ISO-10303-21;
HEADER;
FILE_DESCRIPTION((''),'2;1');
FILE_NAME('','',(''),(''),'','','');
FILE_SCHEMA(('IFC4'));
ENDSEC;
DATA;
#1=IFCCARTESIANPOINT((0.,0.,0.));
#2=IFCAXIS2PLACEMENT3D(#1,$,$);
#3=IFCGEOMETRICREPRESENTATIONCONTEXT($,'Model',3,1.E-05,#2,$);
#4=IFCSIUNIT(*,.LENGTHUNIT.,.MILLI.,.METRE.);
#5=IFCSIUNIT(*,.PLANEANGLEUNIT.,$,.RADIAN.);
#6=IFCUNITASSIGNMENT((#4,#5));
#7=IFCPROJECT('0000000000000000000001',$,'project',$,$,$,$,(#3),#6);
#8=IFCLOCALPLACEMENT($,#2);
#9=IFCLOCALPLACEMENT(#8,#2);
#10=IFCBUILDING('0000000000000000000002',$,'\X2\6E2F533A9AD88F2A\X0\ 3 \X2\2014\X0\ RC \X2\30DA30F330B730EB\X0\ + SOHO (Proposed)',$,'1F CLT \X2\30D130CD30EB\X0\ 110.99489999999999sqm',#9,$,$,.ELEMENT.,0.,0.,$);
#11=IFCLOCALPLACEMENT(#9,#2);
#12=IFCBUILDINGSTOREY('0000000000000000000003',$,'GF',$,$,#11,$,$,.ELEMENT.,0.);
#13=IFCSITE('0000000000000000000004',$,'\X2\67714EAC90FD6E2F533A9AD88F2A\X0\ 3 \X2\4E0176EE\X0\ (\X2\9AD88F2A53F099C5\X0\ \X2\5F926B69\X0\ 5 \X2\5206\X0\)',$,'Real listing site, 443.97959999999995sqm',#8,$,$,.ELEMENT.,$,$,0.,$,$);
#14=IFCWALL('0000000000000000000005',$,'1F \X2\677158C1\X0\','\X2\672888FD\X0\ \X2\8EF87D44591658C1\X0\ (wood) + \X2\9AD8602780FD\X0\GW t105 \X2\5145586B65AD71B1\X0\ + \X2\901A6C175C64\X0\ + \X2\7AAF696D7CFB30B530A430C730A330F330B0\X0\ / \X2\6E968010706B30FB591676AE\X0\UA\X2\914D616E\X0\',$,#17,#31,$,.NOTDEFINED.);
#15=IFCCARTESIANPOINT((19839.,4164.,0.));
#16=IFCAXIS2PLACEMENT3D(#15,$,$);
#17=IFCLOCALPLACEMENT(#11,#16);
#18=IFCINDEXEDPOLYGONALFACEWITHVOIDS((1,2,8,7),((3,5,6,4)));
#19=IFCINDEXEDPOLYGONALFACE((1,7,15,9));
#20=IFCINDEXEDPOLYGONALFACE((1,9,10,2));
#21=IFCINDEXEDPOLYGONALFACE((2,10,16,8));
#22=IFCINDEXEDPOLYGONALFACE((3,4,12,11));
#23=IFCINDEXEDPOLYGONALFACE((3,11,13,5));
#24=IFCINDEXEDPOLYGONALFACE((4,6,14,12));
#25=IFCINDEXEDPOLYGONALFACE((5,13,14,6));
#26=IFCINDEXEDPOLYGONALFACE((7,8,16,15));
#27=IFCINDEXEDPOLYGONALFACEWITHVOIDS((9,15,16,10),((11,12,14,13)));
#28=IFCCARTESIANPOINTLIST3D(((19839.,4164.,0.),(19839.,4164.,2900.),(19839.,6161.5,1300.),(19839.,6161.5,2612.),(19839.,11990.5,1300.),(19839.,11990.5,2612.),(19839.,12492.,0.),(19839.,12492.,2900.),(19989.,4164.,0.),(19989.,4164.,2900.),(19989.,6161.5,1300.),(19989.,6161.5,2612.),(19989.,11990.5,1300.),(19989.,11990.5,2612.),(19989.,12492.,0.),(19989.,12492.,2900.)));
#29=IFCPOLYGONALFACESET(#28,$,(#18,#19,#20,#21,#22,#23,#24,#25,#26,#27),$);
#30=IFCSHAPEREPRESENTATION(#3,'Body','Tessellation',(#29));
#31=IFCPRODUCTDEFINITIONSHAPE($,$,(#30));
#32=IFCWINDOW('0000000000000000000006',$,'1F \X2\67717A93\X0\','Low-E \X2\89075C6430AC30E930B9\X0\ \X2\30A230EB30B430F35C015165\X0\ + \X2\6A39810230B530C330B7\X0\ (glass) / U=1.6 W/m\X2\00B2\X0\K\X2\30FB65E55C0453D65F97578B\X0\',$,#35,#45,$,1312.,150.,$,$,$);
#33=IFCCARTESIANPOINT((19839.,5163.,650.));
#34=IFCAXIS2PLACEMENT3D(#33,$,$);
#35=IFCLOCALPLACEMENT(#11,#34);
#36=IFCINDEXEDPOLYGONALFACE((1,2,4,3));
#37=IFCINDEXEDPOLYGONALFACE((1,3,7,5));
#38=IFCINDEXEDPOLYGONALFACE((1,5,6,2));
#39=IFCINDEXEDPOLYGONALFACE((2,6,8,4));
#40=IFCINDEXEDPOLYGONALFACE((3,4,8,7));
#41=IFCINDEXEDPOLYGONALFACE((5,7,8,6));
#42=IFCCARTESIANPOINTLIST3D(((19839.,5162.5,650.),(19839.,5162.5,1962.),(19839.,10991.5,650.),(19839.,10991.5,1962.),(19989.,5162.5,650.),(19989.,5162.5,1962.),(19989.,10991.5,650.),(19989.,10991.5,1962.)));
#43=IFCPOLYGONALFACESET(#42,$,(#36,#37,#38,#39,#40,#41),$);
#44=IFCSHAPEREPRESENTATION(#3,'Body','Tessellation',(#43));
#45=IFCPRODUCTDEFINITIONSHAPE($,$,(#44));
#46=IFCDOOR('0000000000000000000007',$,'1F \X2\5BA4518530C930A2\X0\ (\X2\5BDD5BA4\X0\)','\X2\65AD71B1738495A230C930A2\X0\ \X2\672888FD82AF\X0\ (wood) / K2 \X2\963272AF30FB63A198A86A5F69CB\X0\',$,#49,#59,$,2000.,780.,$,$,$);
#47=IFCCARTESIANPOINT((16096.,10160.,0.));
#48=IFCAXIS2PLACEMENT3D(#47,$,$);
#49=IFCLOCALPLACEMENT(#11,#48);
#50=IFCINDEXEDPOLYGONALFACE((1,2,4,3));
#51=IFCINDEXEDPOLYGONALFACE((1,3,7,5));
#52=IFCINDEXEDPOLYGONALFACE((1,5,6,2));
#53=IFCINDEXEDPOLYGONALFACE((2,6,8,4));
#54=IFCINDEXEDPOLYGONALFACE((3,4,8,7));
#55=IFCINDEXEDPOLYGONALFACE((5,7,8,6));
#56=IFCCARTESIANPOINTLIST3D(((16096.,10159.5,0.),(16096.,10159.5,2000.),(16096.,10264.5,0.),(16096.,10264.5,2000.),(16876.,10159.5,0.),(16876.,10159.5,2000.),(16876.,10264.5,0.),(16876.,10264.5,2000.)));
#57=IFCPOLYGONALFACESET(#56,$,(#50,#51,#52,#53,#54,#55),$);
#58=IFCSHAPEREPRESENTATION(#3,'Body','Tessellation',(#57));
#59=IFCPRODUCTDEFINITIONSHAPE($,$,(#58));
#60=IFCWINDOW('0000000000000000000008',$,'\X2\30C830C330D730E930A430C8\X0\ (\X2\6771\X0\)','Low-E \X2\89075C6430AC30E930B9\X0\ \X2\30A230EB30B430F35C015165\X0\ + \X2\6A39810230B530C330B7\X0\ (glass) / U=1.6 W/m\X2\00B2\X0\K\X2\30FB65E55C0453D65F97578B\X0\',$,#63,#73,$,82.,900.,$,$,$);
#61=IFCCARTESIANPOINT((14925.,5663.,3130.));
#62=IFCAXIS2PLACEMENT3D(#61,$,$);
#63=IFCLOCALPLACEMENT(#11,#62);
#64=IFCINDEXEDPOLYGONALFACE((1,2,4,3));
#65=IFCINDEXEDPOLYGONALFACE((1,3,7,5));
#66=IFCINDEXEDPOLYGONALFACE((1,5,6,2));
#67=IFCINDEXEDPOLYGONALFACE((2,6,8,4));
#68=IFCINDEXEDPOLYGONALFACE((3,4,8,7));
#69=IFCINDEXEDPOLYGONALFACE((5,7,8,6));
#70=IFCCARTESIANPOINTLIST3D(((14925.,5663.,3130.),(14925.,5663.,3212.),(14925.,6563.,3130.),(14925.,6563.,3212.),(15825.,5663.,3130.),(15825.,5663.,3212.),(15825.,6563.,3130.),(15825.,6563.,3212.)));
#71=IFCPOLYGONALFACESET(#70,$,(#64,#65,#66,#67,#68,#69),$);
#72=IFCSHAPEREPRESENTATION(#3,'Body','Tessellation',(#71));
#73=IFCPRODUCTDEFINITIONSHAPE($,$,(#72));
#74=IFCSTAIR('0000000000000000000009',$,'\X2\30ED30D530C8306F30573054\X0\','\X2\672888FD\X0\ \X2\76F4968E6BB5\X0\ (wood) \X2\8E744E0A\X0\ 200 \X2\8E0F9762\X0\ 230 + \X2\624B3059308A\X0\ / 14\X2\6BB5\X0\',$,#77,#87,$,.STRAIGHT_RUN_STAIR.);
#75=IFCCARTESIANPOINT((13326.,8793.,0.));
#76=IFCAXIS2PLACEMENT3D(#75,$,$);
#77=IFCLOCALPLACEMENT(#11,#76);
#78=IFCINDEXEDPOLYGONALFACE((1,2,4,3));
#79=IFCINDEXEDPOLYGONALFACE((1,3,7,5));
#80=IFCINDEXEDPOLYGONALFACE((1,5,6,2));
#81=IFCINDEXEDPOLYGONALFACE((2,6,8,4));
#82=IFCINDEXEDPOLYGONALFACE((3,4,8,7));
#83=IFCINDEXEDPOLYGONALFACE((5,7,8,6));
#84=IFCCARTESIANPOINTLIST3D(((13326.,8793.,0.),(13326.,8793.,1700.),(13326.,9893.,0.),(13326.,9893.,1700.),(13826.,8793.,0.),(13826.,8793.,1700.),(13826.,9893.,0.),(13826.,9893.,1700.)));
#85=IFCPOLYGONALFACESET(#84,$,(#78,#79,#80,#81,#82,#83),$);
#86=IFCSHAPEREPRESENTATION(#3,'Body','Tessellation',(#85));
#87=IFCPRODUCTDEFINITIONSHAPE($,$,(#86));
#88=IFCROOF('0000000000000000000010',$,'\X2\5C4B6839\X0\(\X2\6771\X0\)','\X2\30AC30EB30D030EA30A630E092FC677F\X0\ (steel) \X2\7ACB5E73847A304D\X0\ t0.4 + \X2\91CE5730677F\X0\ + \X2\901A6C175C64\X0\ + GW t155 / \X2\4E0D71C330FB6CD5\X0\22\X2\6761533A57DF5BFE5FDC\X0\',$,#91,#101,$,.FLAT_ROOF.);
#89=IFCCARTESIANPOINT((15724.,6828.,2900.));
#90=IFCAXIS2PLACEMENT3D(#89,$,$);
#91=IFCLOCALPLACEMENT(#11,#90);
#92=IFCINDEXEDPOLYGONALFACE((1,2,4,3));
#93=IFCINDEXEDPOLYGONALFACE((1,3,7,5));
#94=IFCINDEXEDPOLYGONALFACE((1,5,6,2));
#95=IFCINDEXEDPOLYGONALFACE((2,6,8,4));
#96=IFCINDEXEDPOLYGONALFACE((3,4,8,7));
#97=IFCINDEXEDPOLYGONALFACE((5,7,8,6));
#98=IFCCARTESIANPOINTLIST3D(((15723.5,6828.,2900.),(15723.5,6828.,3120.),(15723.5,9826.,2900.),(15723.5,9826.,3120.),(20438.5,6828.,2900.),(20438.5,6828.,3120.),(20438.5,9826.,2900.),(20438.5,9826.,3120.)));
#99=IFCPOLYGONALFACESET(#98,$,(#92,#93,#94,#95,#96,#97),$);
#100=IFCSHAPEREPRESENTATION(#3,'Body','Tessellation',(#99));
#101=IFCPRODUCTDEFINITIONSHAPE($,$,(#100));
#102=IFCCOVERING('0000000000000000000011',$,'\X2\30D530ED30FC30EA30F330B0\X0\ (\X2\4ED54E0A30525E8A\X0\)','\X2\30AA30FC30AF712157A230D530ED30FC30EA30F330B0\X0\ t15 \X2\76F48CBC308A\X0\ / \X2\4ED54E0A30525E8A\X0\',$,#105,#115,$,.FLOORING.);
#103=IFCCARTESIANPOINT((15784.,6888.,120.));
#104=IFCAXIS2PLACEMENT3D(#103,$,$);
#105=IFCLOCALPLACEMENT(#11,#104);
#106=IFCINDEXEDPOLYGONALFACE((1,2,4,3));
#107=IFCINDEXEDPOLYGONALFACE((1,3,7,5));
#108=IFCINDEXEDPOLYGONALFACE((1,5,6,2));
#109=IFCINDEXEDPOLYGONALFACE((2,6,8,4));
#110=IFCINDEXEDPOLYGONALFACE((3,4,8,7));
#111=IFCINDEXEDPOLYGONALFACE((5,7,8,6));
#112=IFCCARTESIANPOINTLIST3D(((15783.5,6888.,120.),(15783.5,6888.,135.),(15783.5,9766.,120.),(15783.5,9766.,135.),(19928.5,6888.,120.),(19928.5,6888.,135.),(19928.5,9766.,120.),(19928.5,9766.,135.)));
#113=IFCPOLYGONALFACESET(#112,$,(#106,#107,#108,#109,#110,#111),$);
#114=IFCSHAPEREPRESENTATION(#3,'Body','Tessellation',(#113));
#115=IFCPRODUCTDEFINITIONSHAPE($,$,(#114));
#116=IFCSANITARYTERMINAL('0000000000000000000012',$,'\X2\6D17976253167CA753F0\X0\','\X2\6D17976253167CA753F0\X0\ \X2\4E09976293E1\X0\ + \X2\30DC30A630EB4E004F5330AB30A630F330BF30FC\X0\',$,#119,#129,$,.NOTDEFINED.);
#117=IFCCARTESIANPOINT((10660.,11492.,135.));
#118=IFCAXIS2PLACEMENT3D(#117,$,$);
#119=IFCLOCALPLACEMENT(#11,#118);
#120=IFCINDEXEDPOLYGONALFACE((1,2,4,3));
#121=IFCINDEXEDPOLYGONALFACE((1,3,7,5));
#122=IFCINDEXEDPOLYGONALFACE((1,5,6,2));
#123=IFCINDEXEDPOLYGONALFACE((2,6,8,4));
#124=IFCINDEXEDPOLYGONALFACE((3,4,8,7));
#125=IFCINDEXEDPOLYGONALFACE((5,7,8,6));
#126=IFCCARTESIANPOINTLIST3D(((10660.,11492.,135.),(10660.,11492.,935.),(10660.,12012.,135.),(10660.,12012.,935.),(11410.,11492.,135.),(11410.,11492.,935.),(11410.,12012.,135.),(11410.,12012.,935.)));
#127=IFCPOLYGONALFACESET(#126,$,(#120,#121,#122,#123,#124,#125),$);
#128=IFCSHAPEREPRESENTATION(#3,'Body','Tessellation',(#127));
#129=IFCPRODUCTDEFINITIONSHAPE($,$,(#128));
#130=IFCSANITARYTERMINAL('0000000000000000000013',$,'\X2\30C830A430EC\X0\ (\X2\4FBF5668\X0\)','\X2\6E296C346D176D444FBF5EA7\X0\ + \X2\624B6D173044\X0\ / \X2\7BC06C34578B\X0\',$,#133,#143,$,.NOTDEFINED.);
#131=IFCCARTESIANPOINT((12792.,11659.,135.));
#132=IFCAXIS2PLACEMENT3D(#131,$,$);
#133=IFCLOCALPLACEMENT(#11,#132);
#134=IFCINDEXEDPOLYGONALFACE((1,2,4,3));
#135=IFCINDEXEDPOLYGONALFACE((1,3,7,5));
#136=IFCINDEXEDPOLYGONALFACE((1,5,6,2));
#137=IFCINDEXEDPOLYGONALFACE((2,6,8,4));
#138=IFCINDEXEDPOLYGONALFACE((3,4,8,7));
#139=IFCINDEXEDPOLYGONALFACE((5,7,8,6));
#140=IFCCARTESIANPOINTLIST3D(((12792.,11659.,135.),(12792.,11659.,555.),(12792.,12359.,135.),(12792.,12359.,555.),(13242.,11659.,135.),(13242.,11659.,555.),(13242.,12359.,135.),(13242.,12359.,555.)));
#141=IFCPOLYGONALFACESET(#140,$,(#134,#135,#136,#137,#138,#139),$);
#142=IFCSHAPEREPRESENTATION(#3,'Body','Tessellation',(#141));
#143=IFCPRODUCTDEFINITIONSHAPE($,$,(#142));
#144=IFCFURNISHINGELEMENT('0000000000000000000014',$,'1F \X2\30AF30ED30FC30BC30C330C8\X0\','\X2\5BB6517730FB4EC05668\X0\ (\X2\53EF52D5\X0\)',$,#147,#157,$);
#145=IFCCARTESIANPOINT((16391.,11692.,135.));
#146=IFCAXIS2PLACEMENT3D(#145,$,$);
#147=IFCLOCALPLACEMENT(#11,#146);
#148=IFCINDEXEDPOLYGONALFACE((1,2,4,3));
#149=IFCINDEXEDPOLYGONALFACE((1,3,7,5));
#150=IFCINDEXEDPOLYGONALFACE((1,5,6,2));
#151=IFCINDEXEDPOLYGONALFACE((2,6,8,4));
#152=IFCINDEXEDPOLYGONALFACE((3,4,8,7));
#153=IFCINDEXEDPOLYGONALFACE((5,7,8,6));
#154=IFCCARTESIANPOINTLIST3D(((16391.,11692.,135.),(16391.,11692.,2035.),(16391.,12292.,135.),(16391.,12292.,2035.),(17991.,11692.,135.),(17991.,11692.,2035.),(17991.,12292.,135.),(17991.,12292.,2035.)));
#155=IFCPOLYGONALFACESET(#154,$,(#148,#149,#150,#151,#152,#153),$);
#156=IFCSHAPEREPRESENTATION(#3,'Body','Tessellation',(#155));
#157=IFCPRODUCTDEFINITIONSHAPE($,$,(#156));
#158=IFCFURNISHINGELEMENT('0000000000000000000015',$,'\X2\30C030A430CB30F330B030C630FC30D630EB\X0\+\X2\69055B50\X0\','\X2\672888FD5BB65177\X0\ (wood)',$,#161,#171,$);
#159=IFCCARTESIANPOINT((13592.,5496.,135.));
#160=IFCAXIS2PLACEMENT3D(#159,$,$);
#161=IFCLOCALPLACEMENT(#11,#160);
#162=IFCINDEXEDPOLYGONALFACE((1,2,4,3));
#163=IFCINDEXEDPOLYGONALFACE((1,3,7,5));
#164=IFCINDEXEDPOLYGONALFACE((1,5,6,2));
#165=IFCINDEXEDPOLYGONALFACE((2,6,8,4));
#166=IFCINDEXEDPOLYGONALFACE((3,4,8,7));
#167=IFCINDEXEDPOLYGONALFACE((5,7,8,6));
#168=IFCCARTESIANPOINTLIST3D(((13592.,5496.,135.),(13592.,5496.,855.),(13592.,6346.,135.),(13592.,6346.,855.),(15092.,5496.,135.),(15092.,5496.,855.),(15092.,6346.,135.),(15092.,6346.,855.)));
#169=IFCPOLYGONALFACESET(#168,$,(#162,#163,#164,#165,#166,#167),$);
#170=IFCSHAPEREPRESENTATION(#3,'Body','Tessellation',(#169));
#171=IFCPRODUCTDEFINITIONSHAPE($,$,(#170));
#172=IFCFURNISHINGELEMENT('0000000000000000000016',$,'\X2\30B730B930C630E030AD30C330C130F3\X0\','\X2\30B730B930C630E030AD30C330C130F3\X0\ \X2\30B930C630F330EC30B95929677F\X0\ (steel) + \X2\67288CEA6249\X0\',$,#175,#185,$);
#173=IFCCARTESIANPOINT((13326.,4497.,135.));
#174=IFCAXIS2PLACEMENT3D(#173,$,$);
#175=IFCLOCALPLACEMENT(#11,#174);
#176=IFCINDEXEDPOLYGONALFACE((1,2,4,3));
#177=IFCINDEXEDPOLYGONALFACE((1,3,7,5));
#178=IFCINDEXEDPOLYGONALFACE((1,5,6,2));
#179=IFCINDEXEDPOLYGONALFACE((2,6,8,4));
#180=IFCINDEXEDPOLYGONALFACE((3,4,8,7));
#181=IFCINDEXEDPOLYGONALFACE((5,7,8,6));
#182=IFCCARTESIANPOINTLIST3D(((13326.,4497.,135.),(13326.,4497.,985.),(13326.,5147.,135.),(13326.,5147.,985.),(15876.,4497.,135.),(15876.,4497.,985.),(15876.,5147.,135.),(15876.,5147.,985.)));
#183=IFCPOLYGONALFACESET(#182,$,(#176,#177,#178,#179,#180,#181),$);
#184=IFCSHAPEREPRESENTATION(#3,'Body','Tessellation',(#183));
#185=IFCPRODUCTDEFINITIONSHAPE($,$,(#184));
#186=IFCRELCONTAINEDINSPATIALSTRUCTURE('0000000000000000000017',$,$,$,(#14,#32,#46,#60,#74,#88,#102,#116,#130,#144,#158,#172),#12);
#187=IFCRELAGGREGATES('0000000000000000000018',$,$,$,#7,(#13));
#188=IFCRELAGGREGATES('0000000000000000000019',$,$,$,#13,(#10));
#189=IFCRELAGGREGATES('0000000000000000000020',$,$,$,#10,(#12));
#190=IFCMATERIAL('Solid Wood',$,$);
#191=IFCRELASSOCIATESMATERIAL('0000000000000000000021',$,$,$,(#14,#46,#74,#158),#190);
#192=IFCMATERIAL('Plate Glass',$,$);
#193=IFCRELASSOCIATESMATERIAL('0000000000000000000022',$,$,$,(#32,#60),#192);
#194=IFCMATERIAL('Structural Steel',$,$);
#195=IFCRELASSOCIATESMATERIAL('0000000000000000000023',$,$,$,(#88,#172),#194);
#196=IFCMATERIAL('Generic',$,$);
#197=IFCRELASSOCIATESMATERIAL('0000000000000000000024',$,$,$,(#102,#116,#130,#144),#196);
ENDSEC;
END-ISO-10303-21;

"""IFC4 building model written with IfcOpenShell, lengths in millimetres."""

from ifc_helpers import new_model, si_unit, frame, frame_2d, origin, place, context, project, spatial, rectangle, extrude, material, element, fill, save


model = new_model("IFC4")

# Units and contexts
model_context = context("Model", 3, precision=1e-05, world=origin())
ifc_project = project(units=[si_unit("LENGTHUNIT", "METRE", prefix="MILLI"), si_unit("PLANEANGLEUNIT", "RADIAN")], contexts=[model_context])

# Site, building, storey
site_placement = place(None, origin())
site = spatial("IfcSite", under=ifc_project, at=site_placement, Name="東京都港区高輪 3 丁目 (高輪台駅 徒歩 5 分)", ObjectType="Real listing site, 443.97959999999995sqm", CompositionType="ELEMENT", RefElevation=0.0)
building_placement = place(site_placement, origin())
building = spatial("IfcBuilding", under=site, at=building_placement, Name="港区高輪 3 — RC ペンシル + SOHO (Proposed)", ObjectType="1F CLT パネル 110.99489999999999sqm", CompositionType="ELEMENT", ElevationOfRefHeight=0.0, ElevationOfTerrain=0.0)
storey_placement = place(building_placement, origin())
storey = spatial("IfcBuildingStorey", under=building, at=storey_placement, Name="GF", CompositionType="ELEMENT", Elevation=0.0)

# Shared definitions
ifc_material_1 = material(Name="Solid Wood")

# Wall, opening, window
wall_1_placement = place(storey_placement, frame((19839.0, 4164.0, 0.0)))
wall_1 = element("IfcWall", 1, at=wall_1_placement, inside=storey, material=ifc_material_1, Name="1F 東壁", Description="木製 軸組外壁 (wood) + 高性能GW t105 充填断熱 + 通気層 + 窯業系サイディング / 準耐火・外皮UA配慮", PredefinedType="NOTDEFINED", context=model_context, shape_type="SweptSolid", body=[
    extrude(rectangle(XDim=150.0, YDim=8328.0, at=frame_2d((75.0, 4164.0))), frame((19839.0, 4164.0, 0.0)), (0.0, 0.0, 1.0), 2900.0),
])
opening_1_placement = place(storey_placement, frame((19839.0, 5163.0, 650.0)))
opening_1 = element("IfcOpeningElement", 2, at=opening_1_placement, cuts=wall_1, PredefinedType="NOTDEFINED", context=model_context, shape_type="SweptSolid", body=[
    extrude(rectangle(XDim=150.0, YDim=5829.0, at=frame_2d((75.0, 2914.0))), frame((19839.0, 5163.0, 650.0)), (0.0, 0.0, 1.0), 1312.0),
])
ifc_material_2 = material(Name="Plate Glass")
window_1_placement = place(storey_placement, frame((19839.0, 5163.0, 650.0)))
window_1 = element("IfcWindow", 3, at=window_1_placement, inside=storey, material=ifc_material_2, Name="1F 東窓", Description="Low-E 複層ガラス アルゴン封入 + 樹脂サッシ (glass) / U=1.6 W/m²K・日射取得型", OverallHeight=1312.0, OverallWidth=150.0, context=model_context, shape_type="SweptSolid", body=[
    extrude(rectangle(XDim=150.0, YDim=5829.0, at=frame_2d((75.0, 2914.0))), frame((19839.0, 5163.0, 650.0)), (0.0, 0.0, 1.0), 1312.0),
])
fill(opening_1, window_1)

# Door
door_placement = place(storey_placement, frame((16096.0, 10160.0, 0.0)))
element("IfcDoor", 4, at=door_placement, inside=storey, material=ifc_material_1, Name="1F 室内ドア (寝室)", Description="断熱玄関ドア 木製芯 (wood) / K2 防犯・採風機構", OverallHeight=2000.0, OverallWidth=780.0, context=model_context, shape_type="SweptSolid", body=[
    extrude(rectangle(XDim=780.0, YDim=105.0, at=frame_2d((390.0, 52.0))), frame((16096.0, 10160.0, 0.0)), (0.0, 0.0, 1.0), 2000.0),
])

# Window
window_2_placement = place(storey_placement, frame((14925.0, 5663.0, 3130.0)))
element("IfcWindow", 5, at=window_2_placement, inside=storey, material=ifc_material_2, Name="トップライト (東)", Description="Low-E 複層ガラス アルゴン封入 + 樹脂サッシ (glass) / U=1.6 W/m²K・日射取得型", OverallHeight=82.0, OverallWidth=900.0, context=model_context, shape_type="SweptSolid", body=[
    extrude(rectangle(XDim=900.0, YDim=900.0, at=frame_2d((450.0, 450.0))), frame((14925.0, 5663.0, 3130.0)), (0.0, 0.0, 1.0), 82.0),
])

# Stair
stair_placement = place(storey_placement, frame((13326.0, 8793.0, 0.0)))
element("IfcStair", 6, at=stair_placement, inside=storey, material=ifc_material_1, Name="ロフトはしご", Description="木製 直階段 (wood) 蹴上 200 踏面 230 + 手すり / 14段", PredefinedType="STRAIGHT_RUN_STAIR", context=model_context, shape_type="SweptSolid", body=[
    extrude(rectangle(XDim=500.0, YDim=1100.0, at=frame_2d((250.0, 550.0))), frame((13326.0, 8793.0, 0.0)), (0.0, 0.0, 1.0), 1700.0),
])

# Roof
ifc_material_3 = material(Name="Structural Steel")
roof_placement = place(storey_placement, frame((15724.0, 6828.0, 2900.0)))
element("IfcRoof", 7, at=roof_placement, inside=storey, material=ifc_material_3, Name="屋根(東)", Description="ガルバリウム鋼板 (steel) 立平葺き t0.4 + 野地板 + 通気層 + GW t155 / 不燃・法22条区域対応", PredefinedType="FLAT_ROOF", context=model_context, shape_type="SweptSolid", body=[
    extrude(rectangle(XDim=4715.0, YDim=2998.0, at=frame_2d((2357.0, 1499.0))), frame((15724.0, 6828.0, 2900.0)), (0.0, 0.0, 1.0), 220.0),
])

# Covering
ifc_material_4 = material(Name="Generic")
covering_placement = place(storey_placement, frame((15784.0, 6888.0, 120.0)))
element("IfcCovering", 8, at=covering_placement, inside=storey, material=ifc_material_4, Name="フローリング (仕上げ床)", Description="オーク無垢フローリング t15 直貼り / 仕上げ床", PredefinedType="FLOORING", context=model_context, shape_type="SweptSolid", body=[
    extrude(rectangle(XDim=4145.0, YDim=2878.0, at=frame_2d((2072.0, 1439.0))), frame((15784.0, 6888.0, 120.0)), (0.0, 0.0, 1.0), 15.0),
])

# Sanitary terminals
sanitary_terminal_1_placement = place(storey_placement, frame((10660.0, 11492.0, 135.0)))
element("IfcSanitaryTerminal", 9, at=sanitary_terminal_1_placement, inside=storey, material=ifc_material_4, Name="洗面化粧台", Description="洗面化粧台 三面鏡 + ボウル一体カウンター", PredefinedType="NOTDEFINED", context=model_context, shape_type="SweptSolid", body=[
    extrude(rectangle(XDim=750.0, YDim=520.0, at=frame_2d((375.0, 260.0))), frame((10660.0, 11492.0, 135.0)), (0.0, 0.0, 1.0), 800.0),
])
sanitary_terminal_2_placement = place(storey_placement, frame((12792.0, 11659.0, 135.0)))
element("IfcSanitaryTerminal", 10, at=sanitary_terminal_2_placement, inside=storey, material=ifc_material_4, Name="トイレ (便器)", Description="温水洗浄便座 + 手洗い / 節水型", PredefinedType="NOTDEFINED", context=model_context, shape_type="SweptSolid", body=[
    extrude(rectangle(XDim=450.0, YDim=700.0, at=frame_2d((225.0, 350.0))), frame((12792.0, 11659.0, 135.0)), (0.0, 0.0, 1.0), 420.0),
])

# Furnishing elements
furnishing_1_placement = place(storey_placement, frame((16391.0, 11692.0, 135.0)))
element("IfcFurnishingElement", 11, at=furnishing_1_placement, inside=storey, material=ifc_material_4, Name="1F クローゼット", Description="家具・什器 (可動)", context=model_context, shape_type="SweptSolid", body=[
    extrude(rectangle(XDim=1600.0, YDim=600.0, at=frame_2d((800.0, 300.0))), frame((16391.0, 11692.0, 135.0)), (0.0, 0.0, 1.0), 1900.0),
])
furnishing_2_placement = place(storey_placement, frame((13592.0, 5496.0, 135.0)))
element("IfcFurnishingElement", 12, at=furnishing_2_placement, inside=storey, material=ifc_material_1, Name="ダイニングテーブル+椅子", Description="木製家具 (wood)", context=model_context, shape_type="SweptSolid", body=[
    extrude(rectangle(XDim=1500.0, YDim=850.0, at=frame_2d((750.0, 425.0))), frame((13592.0, 5496.0, 135.0)), (0.0, 0.0, 1.0), 720.0),
])
furnishing_3_placement = place(storey_placement, frame((13326.0, 4497.0, 135.0)))
element("IfcFurnishingElement", 13, at=furnishing_3_placement, inside=storey, material=ifc_material_3, Name="システムキッチン", Description="システムキッチン ステンレス天板 (steel) + 木質扉", context=model_context, shape_type="SweptSolid", body=[
    extrude(rectangle(XDim=2550.0, YDim=650.0, at=frame_2d((1275.0, 325.0))), frame((13326.0, 4497.0, 135.0)), (0.0, 0.0, 1.0), 850.0),
])

save(model, "model.ifc")
